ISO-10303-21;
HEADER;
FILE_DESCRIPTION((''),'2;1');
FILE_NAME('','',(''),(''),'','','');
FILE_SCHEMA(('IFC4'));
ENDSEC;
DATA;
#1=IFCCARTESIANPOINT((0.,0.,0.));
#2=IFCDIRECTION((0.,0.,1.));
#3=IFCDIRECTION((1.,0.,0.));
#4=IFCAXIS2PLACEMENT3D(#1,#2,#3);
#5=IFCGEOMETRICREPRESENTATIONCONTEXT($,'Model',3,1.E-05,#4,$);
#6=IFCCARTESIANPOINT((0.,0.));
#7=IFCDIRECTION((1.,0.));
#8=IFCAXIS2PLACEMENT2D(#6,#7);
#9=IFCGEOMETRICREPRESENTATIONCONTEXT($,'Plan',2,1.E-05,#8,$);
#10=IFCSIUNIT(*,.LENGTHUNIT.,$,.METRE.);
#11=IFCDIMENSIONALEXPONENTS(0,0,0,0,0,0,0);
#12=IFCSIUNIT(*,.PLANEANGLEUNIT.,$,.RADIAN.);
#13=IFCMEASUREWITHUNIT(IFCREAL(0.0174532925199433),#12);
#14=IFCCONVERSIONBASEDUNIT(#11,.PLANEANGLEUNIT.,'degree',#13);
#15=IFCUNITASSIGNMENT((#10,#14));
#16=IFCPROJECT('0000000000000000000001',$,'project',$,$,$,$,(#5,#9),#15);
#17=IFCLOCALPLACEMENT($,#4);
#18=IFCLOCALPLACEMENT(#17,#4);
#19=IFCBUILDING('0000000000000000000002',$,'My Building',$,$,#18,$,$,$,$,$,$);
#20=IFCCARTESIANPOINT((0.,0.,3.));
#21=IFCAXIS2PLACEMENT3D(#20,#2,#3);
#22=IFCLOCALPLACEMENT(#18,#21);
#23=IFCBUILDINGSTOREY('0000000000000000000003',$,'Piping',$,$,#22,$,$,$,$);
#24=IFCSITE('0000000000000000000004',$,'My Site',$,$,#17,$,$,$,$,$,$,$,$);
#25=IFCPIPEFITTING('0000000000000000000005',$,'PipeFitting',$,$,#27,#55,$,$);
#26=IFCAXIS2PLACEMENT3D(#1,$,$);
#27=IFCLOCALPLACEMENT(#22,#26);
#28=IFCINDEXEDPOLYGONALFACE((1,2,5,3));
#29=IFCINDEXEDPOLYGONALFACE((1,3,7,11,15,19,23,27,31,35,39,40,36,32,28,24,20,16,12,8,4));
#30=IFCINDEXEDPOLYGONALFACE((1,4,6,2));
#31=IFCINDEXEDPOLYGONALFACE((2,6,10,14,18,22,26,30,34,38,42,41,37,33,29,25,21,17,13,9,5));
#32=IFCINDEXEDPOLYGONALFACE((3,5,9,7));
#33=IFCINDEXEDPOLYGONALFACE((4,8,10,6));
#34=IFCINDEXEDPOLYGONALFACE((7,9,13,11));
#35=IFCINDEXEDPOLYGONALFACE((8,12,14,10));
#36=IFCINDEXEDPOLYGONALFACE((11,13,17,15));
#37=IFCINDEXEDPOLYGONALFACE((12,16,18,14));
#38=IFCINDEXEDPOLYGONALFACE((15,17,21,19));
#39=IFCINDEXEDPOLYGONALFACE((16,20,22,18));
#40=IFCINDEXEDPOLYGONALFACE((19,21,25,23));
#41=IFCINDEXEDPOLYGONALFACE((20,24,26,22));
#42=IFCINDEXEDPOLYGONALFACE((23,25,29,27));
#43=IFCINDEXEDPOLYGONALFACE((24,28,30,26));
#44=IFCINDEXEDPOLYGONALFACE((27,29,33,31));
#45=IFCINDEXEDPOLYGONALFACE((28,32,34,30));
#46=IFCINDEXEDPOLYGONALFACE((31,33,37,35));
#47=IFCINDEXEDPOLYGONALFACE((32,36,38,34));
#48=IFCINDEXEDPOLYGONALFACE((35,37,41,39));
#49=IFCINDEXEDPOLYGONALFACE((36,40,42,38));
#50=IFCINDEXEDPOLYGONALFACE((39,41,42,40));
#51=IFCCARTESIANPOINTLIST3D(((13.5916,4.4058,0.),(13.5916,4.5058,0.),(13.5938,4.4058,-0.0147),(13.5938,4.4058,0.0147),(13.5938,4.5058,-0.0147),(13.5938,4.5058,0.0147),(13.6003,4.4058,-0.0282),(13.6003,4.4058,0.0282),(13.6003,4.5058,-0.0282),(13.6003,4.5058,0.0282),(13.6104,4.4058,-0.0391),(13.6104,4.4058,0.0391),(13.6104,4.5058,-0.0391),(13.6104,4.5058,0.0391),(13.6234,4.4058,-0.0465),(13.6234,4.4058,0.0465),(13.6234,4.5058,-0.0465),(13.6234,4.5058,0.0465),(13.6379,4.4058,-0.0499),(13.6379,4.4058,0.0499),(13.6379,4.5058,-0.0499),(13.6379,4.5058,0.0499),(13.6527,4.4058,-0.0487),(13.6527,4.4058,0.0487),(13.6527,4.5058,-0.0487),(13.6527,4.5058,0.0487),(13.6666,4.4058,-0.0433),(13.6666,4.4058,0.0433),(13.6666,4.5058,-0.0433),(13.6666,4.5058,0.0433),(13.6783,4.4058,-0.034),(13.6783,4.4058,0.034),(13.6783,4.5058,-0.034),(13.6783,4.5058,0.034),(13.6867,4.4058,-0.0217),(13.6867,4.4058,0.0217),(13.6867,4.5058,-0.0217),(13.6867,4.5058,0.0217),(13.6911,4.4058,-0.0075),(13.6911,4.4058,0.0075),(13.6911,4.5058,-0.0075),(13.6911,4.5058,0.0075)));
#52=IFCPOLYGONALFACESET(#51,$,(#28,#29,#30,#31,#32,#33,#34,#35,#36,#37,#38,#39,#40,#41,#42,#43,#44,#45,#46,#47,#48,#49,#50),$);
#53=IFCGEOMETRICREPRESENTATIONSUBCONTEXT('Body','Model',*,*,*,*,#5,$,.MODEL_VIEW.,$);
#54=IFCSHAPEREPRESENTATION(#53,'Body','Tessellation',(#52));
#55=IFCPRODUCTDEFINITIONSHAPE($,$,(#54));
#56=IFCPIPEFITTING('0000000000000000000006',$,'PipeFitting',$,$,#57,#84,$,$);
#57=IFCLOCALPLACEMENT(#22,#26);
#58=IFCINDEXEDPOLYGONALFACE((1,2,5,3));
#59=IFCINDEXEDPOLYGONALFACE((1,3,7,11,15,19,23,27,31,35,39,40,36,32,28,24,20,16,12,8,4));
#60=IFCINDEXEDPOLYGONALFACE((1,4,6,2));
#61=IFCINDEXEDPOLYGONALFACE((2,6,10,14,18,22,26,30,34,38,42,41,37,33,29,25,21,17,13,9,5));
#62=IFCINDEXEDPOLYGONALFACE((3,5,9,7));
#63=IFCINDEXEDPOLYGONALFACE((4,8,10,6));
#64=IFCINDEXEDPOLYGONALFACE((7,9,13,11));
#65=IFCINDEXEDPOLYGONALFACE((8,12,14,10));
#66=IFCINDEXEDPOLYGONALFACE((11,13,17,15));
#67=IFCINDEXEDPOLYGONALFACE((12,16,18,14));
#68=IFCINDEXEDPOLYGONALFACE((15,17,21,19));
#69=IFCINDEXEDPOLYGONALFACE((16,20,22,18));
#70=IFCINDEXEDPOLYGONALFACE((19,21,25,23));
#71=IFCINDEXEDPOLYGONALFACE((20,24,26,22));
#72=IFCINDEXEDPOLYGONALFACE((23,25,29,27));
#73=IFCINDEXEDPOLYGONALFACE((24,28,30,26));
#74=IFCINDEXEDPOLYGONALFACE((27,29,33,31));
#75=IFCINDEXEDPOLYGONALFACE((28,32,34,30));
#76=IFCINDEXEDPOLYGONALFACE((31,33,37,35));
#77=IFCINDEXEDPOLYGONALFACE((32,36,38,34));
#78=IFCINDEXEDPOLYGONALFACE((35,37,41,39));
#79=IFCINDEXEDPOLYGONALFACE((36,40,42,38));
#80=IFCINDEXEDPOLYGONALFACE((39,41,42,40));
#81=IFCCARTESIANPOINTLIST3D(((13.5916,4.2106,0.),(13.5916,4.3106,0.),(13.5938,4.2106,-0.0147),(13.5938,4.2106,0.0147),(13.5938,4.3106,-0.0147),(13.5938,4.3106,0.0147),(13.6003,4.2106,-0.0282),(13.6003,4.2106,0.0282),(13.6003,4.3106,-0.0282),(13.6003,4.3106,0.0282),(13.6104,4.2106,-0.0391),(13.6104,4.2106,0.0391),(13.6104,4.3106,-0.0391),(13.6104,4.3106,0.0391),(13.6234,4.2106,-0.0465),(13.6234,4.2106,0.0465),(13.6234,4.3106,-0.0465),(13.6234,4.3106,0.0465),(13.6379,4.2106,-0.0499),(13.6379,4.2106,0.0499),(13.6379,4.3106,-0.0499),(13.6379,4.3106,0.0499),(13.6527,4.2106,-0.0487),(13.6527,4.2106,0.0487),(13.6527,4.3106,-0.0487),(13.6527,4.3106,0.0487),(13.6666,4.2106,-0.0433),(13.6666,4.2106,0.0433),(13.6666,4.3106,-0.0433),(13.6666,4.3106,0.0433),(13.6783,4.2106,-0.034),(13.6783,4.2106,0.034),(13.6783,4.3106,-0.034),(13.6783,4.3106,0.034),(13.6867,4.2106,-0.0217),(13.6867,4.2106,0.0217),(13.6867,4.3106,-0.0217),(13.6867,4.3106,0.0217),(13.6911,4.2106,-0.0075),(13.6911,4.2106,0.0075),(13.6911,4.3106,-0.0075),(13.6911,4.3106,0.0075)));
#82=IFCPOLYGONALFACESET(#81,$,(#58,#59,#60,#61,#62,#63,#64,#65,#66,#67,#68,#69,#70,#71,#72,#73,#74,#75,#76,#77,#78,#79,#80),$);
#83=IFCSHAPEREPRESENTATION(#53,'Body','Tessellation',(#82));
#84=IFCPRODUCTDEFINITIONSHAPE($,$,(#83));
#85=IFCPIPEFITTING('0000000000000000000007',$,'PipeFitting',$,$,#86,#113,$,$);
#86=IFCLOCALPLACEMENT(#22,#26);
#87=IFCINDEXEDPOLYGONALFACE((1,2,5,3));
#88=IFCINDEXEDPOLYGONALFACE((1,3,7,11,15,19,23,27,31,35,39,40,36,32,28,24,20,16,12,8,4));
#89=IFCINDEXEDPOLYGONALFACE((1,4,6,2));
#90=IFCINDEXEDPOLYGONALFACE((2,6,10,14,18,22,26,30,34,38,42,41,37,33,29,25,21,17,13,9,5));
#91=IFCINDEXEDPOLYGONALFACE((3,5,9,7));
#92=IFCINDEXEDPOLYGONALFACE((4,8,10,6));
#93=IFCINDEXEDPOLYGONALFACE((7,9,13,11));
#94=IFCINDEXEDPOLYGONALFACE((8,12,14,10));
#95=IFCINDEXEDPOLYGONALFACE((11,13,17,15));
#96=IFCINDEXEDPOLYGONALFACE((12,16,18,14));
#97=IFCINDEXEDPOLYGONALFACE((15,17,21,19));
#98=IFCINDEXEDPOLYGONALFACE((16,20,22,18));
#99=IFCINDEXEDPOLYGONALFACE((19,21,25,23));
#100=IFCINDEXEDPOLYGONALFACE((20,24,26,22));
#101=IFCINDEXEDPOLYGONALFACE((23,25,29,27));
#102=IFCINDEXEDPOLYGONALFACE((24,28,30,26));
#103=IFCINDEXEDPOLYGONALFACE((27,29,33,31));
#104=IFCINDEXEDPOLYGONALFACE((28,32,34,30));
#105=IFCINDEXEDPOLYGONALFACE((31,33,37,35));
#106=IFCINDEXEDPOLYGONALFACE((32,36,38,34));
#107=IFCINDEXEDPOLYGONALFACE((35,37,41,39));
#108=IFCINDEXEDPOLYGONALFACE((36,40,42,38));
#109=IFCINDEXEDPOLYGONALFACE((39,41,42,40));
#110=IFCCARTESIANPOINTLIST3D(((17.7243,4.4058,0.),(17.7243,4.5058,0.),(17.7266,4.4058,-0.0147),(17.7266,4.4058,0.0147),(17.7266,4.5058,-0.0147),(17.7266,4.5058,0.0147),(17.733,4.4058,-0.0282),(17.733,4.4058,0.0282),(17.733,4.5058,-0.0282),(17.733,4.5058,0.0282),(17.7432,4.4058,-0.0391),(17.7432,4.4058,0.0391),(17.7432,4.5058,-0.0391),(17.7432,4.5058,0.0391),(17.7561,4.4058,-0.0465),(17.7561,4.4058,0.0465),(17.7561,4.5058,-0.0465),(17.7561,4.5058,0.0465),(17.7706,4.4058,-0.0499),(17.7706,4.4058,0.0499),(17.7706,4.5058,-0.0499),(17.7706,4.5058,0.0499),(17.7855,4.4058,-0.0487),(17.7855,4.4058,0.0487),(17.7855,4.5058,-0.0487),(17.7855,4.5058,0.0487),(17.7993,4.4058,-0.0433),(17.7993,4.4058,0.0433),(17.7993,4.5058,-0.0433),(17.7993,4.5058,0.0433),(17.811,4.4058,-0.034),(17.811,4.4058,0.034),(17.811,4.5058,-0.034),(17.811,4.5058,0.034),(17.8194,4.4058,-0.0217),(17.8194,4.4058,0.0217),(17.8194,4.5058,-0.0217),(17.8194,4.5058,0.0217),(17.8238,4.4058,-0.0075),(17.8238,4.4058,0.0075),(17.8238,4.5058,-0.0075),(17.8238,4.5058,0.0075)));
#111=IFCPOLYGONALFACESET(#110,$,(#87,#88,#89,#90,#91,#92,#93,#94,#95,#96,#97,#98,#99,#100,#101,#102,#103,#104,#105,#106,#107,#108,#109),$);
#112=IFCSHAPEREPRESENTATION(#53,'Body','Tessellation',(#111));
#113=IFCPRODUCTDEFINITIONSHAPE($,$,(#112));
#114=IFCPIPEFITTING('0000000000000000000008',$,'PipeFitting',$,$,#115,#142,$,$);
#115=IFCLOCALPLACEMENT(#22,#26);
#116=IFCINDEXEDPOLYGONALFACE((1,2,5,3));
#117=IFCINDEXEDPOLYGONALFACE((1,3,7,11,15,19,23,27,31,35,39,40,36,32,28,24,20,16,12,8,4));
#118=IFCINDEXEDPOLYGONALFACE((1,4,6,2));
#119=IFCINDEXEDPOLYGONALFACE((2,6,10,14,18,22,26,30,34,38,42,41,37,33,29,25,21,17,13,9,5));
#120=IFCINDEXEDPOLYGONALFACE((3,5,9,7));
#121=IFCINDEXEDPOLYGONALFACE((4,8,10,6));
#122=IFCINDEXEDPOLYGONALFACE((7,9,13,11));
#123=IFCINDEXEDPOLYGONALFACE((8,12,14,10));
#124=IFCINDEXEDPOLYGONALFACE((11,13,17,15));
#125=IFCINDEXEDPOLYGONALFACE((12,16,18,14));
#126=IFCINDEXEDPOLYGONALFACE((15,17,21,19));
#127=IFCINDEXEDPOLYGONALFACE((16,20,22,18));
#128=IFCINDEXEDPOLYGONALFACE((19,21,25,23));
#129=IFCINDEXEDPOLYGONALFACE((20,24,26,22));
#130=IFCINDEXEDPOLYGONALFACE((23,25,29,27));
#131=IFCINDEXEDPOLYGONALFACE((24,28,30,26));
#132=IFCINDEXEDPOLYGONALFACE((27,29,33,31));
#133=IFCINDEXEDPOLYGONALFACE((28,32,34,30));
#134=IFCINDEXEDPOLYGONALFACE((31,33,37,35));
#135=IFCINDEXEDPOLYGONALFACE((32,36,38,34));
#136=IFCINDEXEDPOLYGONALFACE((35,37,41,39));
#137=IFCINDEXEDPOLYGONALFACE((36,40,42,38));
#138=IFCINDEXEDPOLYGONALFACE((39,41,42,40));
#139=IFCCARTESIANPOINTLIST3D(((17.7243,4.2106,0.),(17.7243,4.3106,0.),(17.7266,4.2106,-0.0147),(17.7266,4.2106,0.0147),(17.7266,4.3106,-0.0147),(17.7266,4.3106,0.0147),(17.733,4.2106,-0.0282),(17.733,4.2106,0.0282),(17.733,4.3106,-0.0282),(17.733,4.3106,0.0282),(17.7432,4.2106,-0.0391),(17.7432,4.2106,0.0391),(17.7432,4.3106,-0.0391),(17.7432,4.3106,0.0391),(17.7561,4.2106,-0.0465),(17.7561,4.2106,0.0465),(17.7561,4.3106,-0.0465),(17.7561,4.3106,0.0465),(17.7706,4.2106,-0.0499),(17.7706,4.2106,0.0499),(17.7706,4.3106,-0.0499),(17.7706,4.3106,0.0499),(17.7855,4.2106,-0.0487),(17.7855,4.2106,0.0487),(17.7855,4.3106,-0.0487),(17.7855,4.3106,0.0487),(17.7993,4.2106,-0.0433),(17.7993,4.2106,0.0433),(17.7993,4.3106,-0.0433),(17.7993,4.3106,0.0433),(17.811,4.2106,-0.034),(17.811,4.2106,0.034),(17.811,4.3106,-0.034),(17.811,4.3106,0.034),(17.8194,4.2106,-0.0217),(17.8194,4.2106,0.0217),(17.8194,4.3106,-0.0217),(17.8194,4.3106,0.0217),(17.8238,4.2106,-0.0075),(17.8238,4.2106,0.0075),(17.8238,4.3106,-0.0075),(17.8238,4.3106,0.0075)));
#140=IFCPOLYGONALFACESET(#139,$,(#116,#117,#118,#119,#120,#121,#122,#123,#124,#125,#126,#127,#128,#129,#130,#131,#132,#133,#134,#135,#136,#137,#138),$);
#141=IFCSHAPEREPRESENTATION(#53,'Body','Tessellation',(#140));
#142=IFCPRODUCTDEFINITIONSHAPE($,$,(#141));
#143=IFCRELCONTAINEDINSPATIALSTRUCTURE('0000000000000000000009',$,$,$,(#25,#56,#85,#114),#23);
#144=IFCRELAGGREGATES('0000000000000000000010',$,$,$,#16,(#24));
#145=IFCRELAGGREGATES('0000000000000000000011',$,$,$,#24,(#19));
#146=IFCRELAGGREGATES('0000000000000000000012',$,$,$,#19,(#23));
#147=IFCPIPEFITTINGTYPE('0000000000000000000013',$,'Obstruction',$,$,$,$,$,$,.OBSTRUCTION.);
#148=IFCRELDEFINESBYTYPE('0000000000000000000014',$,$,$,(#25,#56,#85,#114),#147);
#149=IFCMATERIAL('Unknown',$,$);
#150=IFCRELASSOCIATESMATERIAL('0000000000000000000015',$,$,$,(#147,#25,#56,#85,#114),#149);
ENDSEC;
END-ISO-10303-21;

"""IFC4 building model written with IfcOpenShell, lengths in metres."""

from ifc_helpers import new_model, entity, si_unit, converted_unit, frame, origin_with_axes, origin_2d_with_axis, place, context, subcontext, project, spatial, circle, extrude, material, material_profile, profile_set, profile_usage, type_object, element, save


model = new_model("IFC4")

# Units and contexts
model_context = context("Model", 3, precision=1e-05, world=origin_with_axes())
plan_context = context("Plan", 2, precision=1e-05, world=origin_2d_with_axis())
body_context = subcontext(model_context, "Body", "Model", "MODEL_VIEW")
ifc_project = project(units=[si_unit("LENGTHUNIT", "METRE"), converted_unit("PLANEANGLEUNIT", "degree", entity("IfcReal", 0.0174532925199433), si_unit("PLANEANGLEUNIT", "RADIAN"), dimensions=[0, 0, 0, 0, 0, 0, 0])], contexts=[model_context, plan_context])

# Site, building, storey
site_placement = place(None, origin_with_axes())
site = spatial("IfcSite", under=ifc_project, at=site_placement, Name="My Site")
building_placement = place(site_placement, origin_with_axes())
building = spatial("IfcBuilding", under=site, at=building_placement, Name="My Building")
storey_placement = place(building_placement, frame((0.0, 0.0, 3.0), z_axis=(0.0, 0.0, 1.0), x_axis=(1.0, 0.0, 0.0)))
storey = spatial("IfcBuildingStorey", under=building, at=storey_placement, Name="Piping")

# Shared definitions
ifc_material = material(Name="Unknown")

# Pipe fittings
ifc_material_profile_1 = material_profile(ifc_material, circle(Radius=0.05))
ifc_profile_set_1 = profile_set([ifc_material_profile_1])
ifc_profile_usage_1 = profile_usage(ifc_profile_set_1, cardinal=5)
pipe_fitting_type_1 = type_object("IfcPipeFittingType", Name="Obstruction", PredefinedType="OBSTRUCTION", material=ifc_profile_set_1)
pipe_fitting_1_placement = place(storey_placement, frame((13.6416, 4.5058, 0.0), z_axis=(0.0, -1.0, 0.0), x_axis=(-1.0, 0.0, 0.0)))
element("IfcPipeFitting", 1, at=pipe_fitting_1_placement, inside=storey, type_object=pipe_fitting_type_1, material=ifc_profile_usage_1, Name="PipeFitting", context=body_context, shape_type="SweptSolid", body=[
    extrude(circle(Radius=0.05), origin_with_axes(), (0.0, 0.0, 1.0), 0.1),
])
ifc_profile_usage_2 = profile_usage(ifc_profile_set_1, cardinal=5)
pipe_fitting_2_placement = place(storey_placement, frame((13.6416, 4.3106, 0.0), z_axis=(0.0, -1.0, 0.0), x_axis=(-1.0, 0.0, 0.0)))
element("IfcPipeFitting", 2, at=pipe_fitting_2_placement, inside=storey, type_object=pipe_fitting_type_1, material=ifc_profile_usage_2, Name="PipeFitting", context=body_context, shape_type="SweptSolid", body=[
    extrude(circle(Radius=0.05), origin_with_axes(), (0.0, 0.0, 1.0), 0.1),
])
ifc_profile_usage_3 = profile_usage(ifc_profile_set_1, cardinal=5)
pipe_fitting_3_placement = place(storey_placement, frame((17.7743, 4.5058, 0.0), z_axis=(0.0, -1.0, 0.0), x_axis=(-1.0, 0.0, 0.0)))
element("IfcPipeFitting", 3, at=pipe_fitting_3_placement, inside=storey, type_object=pipe_fitting_type_1, material=ifc_profile_usage_3, Name="PipeFitting", context=body_context, shape_type="SweptSolid", body=[
    extrude(circle(Radius=0.05), origin_with_axes(), (0.0, 0.0, 1.0), 0.1),
])
ifc_profile_usage_4 = profile_usage(ifc_profile_set_1, cardinal=5)
pipe_fitting_4_placement = place(storey_placement, frame((17.7743, 4.3106, 0.0), z_axis=(0.0, -1.0, 0.0), x_axis=(-1.0, 0.0, 0.0)))
element("IfcPipeFitting", 4, at=pipe_fitting_4_placement, inside=storey, type_object=pipe_fitting_type_1, material=ifc_profile_usage_4, Name="PipeFitting", context=body_context, shape_type="SweptSolid", body=[
    extrude(circle(Radius=0.05), origin_with_axes(), (0.0, 0.0, 1.0), 0.1),
])

save(model, "model.ifc")
